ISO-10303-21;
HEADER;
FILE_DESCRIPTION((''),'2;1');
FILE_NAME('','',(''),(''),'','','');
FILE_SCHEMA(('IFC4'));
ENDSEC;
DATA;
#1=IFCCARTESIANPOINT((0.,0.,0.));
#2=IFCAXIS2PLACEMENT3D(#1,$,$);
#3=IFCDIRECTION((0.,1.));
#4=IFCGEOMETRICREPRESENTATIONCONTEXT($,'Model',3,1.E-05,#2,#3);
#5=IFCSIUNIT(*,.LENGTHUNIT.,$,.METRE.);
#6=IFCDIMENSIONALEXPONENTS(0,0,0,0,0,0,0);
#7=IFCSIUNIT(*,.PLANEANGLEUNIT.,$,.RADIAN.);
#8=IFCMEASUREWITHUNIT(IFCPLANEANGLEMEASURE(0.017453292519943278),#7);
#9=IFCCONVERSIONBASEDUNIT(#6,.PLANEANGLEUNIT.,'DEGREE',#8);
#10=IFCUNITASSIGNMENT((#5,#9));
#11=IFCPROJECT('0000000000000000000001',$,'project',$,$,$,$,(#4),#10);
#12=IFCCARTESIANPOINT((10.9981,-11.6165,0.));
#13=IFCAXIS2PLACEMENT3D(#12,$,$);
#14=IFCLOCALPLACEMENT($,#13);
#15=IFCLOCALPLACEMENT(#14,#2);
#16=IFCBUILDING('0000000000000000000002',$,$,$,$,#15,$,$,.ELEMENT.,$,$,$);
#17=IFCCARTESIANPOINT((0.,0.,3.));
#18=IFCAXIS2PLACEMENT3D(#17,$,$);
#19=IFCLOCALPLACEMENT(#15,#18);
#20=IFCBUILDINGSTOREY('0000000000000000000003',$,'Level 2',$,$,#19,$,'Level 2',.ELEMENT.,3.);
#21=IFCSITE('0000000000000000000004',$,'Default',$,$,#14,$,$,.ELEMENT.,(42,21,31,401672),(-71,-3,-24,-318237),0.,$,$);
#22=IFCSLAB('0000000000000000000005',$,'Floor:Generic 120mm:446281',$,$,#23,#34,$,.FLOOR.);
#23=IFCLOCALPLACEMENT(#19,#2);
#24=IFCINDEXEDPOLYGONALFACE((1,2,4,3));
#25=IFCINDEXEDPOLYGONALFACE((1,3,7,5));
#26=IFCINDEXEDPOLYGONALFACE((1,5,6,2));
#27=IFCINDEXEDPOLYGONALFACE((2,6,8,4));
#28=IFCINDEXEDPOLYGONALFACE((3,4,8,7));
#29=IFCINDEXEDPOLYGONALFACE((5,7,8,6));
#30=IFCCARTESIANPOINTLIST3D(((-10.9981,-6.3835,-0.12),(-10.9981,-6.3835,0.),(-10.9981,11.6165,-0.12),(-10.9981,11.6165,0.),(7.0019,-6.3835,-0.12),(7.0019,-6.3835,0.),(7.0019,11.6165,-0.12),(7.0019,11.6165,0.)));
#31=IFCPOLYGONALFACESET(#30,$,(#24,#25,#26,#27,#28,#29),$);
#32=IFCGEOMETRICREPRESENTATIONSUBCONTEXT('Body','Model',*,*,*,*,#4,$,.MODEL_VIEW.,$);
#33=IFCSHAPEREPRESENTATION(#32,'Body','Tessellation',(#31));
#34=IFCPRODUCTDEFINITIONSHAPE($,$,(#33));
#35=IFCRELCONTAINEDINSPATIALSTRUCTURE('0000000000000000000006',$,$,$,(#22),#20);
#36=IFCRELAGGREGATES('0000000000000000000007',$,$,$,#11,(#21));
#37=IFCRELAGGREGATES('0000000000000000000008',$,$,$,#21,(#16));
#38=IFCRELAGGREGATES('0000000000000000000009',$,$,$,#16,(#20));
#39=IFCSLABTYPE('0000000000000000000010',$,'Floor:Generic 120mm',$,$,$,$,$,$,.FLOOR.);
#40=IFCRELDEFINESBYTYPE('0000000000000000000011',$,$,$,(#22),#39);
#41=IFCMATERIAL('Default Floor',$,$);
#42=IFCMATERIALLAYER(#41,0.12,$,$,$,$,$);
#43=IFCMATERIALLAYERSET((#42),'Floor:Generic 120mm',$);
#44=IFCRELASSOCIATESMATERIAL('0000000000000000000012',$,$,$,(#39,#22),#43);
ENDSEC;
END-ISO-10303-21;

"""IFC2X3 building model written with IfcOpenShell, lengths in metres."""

from ifc_helpers import new_model, entity, si_unit, converted_unit, direction, frame, origin, origin_2d_with_axis, place, context, subcontext, project, spatial, rectangle, extrude, material, layer, layer_set, layer_usage, type_object, element, save


model = new_model("IFC2X3")

# Units and contexts
model_context = context("Model", 3, precision=1e-05, world=origin(), true_north=direction((0.0, 1.0)))
body_context = subcontext(model_context, "Body", "Model", "MODEL_VIEW")
ifc_project = project(units=[si_unit("LENGTHUNIT", "METRE"), converted_unit("PLANEANGLEUNIT", "DEGREE", entity("IfcPlaneAngleMeasure", 0.017453292519943278), si_unit("PLANEANGLEUNIT", "RADIAN"), dimensions=[0, 0, 0, 0, 0, 0, 0])], contexts=[model_context])

# Site, building, storey
site_placement = place(None, frame((10.9981, -11.6165, 0.0)))
site = spatial("IfcSite", under=ifc_project, at=site_placement, Name="Default", CompositionType="ELEMENT", RefLatitude=(42, 21, 31, 401672), RefLongitude=(-71, -3, -24, -318237), RefElevation=0.0)
building_placement = place(site_placement, origin())
building = spatial("IfcBuilding", under=site, at=building_placement, CompositionType="ELEMENT")
storey_placement = place(building_placement, frame((0.0, 0.0, 3.0)))
storey = spatial("IfcBuildingStorey", under=building, at=storey_placement, Name="Level 2", LongName="Level 2", CompositionType="ELEMENT", Elevation=3.0)

# Slab
ifc_material_1 = material(Name="Default Floor")
ifc_layer = layer(ifc_material_1, 0.12)
ifc_layer_set = layer_set([ifc_layer], Name="Floor:Generic 120mm")
ifc_layer_usage = layer_usage(ifc_layer_set, "AXIS3", "POSITIVE", 0.0)
slab_type = type_object("IfcSlabType", Name="Floor:Generic 120mm", PredefinedType="FLOOR", material=ifc_layer_set)
slab_placement = place(storey_placement, origin())
element("IfcSlab", 1, at=slab_placement, inside=storey, type_object=slab_type, material=ifc_layer_usage, Name="Floor:Generic 120mm:446281", PredefinedType="FLOOR", context=body_context, shape_type="SweptSolid", body=[
    extrude(rectangle(XDim=18.0, YDim=18.0, at=origin_2d_with_axis()), frame((-1.9981, 2.6165, 0.0), z_axis=(0.0, 0.0, -1.0), x_axis=(0.0, 1.0, 0.0)), (0.0, 0.0, 1.0), 0.12),
])

save(model, "model.ifc")
